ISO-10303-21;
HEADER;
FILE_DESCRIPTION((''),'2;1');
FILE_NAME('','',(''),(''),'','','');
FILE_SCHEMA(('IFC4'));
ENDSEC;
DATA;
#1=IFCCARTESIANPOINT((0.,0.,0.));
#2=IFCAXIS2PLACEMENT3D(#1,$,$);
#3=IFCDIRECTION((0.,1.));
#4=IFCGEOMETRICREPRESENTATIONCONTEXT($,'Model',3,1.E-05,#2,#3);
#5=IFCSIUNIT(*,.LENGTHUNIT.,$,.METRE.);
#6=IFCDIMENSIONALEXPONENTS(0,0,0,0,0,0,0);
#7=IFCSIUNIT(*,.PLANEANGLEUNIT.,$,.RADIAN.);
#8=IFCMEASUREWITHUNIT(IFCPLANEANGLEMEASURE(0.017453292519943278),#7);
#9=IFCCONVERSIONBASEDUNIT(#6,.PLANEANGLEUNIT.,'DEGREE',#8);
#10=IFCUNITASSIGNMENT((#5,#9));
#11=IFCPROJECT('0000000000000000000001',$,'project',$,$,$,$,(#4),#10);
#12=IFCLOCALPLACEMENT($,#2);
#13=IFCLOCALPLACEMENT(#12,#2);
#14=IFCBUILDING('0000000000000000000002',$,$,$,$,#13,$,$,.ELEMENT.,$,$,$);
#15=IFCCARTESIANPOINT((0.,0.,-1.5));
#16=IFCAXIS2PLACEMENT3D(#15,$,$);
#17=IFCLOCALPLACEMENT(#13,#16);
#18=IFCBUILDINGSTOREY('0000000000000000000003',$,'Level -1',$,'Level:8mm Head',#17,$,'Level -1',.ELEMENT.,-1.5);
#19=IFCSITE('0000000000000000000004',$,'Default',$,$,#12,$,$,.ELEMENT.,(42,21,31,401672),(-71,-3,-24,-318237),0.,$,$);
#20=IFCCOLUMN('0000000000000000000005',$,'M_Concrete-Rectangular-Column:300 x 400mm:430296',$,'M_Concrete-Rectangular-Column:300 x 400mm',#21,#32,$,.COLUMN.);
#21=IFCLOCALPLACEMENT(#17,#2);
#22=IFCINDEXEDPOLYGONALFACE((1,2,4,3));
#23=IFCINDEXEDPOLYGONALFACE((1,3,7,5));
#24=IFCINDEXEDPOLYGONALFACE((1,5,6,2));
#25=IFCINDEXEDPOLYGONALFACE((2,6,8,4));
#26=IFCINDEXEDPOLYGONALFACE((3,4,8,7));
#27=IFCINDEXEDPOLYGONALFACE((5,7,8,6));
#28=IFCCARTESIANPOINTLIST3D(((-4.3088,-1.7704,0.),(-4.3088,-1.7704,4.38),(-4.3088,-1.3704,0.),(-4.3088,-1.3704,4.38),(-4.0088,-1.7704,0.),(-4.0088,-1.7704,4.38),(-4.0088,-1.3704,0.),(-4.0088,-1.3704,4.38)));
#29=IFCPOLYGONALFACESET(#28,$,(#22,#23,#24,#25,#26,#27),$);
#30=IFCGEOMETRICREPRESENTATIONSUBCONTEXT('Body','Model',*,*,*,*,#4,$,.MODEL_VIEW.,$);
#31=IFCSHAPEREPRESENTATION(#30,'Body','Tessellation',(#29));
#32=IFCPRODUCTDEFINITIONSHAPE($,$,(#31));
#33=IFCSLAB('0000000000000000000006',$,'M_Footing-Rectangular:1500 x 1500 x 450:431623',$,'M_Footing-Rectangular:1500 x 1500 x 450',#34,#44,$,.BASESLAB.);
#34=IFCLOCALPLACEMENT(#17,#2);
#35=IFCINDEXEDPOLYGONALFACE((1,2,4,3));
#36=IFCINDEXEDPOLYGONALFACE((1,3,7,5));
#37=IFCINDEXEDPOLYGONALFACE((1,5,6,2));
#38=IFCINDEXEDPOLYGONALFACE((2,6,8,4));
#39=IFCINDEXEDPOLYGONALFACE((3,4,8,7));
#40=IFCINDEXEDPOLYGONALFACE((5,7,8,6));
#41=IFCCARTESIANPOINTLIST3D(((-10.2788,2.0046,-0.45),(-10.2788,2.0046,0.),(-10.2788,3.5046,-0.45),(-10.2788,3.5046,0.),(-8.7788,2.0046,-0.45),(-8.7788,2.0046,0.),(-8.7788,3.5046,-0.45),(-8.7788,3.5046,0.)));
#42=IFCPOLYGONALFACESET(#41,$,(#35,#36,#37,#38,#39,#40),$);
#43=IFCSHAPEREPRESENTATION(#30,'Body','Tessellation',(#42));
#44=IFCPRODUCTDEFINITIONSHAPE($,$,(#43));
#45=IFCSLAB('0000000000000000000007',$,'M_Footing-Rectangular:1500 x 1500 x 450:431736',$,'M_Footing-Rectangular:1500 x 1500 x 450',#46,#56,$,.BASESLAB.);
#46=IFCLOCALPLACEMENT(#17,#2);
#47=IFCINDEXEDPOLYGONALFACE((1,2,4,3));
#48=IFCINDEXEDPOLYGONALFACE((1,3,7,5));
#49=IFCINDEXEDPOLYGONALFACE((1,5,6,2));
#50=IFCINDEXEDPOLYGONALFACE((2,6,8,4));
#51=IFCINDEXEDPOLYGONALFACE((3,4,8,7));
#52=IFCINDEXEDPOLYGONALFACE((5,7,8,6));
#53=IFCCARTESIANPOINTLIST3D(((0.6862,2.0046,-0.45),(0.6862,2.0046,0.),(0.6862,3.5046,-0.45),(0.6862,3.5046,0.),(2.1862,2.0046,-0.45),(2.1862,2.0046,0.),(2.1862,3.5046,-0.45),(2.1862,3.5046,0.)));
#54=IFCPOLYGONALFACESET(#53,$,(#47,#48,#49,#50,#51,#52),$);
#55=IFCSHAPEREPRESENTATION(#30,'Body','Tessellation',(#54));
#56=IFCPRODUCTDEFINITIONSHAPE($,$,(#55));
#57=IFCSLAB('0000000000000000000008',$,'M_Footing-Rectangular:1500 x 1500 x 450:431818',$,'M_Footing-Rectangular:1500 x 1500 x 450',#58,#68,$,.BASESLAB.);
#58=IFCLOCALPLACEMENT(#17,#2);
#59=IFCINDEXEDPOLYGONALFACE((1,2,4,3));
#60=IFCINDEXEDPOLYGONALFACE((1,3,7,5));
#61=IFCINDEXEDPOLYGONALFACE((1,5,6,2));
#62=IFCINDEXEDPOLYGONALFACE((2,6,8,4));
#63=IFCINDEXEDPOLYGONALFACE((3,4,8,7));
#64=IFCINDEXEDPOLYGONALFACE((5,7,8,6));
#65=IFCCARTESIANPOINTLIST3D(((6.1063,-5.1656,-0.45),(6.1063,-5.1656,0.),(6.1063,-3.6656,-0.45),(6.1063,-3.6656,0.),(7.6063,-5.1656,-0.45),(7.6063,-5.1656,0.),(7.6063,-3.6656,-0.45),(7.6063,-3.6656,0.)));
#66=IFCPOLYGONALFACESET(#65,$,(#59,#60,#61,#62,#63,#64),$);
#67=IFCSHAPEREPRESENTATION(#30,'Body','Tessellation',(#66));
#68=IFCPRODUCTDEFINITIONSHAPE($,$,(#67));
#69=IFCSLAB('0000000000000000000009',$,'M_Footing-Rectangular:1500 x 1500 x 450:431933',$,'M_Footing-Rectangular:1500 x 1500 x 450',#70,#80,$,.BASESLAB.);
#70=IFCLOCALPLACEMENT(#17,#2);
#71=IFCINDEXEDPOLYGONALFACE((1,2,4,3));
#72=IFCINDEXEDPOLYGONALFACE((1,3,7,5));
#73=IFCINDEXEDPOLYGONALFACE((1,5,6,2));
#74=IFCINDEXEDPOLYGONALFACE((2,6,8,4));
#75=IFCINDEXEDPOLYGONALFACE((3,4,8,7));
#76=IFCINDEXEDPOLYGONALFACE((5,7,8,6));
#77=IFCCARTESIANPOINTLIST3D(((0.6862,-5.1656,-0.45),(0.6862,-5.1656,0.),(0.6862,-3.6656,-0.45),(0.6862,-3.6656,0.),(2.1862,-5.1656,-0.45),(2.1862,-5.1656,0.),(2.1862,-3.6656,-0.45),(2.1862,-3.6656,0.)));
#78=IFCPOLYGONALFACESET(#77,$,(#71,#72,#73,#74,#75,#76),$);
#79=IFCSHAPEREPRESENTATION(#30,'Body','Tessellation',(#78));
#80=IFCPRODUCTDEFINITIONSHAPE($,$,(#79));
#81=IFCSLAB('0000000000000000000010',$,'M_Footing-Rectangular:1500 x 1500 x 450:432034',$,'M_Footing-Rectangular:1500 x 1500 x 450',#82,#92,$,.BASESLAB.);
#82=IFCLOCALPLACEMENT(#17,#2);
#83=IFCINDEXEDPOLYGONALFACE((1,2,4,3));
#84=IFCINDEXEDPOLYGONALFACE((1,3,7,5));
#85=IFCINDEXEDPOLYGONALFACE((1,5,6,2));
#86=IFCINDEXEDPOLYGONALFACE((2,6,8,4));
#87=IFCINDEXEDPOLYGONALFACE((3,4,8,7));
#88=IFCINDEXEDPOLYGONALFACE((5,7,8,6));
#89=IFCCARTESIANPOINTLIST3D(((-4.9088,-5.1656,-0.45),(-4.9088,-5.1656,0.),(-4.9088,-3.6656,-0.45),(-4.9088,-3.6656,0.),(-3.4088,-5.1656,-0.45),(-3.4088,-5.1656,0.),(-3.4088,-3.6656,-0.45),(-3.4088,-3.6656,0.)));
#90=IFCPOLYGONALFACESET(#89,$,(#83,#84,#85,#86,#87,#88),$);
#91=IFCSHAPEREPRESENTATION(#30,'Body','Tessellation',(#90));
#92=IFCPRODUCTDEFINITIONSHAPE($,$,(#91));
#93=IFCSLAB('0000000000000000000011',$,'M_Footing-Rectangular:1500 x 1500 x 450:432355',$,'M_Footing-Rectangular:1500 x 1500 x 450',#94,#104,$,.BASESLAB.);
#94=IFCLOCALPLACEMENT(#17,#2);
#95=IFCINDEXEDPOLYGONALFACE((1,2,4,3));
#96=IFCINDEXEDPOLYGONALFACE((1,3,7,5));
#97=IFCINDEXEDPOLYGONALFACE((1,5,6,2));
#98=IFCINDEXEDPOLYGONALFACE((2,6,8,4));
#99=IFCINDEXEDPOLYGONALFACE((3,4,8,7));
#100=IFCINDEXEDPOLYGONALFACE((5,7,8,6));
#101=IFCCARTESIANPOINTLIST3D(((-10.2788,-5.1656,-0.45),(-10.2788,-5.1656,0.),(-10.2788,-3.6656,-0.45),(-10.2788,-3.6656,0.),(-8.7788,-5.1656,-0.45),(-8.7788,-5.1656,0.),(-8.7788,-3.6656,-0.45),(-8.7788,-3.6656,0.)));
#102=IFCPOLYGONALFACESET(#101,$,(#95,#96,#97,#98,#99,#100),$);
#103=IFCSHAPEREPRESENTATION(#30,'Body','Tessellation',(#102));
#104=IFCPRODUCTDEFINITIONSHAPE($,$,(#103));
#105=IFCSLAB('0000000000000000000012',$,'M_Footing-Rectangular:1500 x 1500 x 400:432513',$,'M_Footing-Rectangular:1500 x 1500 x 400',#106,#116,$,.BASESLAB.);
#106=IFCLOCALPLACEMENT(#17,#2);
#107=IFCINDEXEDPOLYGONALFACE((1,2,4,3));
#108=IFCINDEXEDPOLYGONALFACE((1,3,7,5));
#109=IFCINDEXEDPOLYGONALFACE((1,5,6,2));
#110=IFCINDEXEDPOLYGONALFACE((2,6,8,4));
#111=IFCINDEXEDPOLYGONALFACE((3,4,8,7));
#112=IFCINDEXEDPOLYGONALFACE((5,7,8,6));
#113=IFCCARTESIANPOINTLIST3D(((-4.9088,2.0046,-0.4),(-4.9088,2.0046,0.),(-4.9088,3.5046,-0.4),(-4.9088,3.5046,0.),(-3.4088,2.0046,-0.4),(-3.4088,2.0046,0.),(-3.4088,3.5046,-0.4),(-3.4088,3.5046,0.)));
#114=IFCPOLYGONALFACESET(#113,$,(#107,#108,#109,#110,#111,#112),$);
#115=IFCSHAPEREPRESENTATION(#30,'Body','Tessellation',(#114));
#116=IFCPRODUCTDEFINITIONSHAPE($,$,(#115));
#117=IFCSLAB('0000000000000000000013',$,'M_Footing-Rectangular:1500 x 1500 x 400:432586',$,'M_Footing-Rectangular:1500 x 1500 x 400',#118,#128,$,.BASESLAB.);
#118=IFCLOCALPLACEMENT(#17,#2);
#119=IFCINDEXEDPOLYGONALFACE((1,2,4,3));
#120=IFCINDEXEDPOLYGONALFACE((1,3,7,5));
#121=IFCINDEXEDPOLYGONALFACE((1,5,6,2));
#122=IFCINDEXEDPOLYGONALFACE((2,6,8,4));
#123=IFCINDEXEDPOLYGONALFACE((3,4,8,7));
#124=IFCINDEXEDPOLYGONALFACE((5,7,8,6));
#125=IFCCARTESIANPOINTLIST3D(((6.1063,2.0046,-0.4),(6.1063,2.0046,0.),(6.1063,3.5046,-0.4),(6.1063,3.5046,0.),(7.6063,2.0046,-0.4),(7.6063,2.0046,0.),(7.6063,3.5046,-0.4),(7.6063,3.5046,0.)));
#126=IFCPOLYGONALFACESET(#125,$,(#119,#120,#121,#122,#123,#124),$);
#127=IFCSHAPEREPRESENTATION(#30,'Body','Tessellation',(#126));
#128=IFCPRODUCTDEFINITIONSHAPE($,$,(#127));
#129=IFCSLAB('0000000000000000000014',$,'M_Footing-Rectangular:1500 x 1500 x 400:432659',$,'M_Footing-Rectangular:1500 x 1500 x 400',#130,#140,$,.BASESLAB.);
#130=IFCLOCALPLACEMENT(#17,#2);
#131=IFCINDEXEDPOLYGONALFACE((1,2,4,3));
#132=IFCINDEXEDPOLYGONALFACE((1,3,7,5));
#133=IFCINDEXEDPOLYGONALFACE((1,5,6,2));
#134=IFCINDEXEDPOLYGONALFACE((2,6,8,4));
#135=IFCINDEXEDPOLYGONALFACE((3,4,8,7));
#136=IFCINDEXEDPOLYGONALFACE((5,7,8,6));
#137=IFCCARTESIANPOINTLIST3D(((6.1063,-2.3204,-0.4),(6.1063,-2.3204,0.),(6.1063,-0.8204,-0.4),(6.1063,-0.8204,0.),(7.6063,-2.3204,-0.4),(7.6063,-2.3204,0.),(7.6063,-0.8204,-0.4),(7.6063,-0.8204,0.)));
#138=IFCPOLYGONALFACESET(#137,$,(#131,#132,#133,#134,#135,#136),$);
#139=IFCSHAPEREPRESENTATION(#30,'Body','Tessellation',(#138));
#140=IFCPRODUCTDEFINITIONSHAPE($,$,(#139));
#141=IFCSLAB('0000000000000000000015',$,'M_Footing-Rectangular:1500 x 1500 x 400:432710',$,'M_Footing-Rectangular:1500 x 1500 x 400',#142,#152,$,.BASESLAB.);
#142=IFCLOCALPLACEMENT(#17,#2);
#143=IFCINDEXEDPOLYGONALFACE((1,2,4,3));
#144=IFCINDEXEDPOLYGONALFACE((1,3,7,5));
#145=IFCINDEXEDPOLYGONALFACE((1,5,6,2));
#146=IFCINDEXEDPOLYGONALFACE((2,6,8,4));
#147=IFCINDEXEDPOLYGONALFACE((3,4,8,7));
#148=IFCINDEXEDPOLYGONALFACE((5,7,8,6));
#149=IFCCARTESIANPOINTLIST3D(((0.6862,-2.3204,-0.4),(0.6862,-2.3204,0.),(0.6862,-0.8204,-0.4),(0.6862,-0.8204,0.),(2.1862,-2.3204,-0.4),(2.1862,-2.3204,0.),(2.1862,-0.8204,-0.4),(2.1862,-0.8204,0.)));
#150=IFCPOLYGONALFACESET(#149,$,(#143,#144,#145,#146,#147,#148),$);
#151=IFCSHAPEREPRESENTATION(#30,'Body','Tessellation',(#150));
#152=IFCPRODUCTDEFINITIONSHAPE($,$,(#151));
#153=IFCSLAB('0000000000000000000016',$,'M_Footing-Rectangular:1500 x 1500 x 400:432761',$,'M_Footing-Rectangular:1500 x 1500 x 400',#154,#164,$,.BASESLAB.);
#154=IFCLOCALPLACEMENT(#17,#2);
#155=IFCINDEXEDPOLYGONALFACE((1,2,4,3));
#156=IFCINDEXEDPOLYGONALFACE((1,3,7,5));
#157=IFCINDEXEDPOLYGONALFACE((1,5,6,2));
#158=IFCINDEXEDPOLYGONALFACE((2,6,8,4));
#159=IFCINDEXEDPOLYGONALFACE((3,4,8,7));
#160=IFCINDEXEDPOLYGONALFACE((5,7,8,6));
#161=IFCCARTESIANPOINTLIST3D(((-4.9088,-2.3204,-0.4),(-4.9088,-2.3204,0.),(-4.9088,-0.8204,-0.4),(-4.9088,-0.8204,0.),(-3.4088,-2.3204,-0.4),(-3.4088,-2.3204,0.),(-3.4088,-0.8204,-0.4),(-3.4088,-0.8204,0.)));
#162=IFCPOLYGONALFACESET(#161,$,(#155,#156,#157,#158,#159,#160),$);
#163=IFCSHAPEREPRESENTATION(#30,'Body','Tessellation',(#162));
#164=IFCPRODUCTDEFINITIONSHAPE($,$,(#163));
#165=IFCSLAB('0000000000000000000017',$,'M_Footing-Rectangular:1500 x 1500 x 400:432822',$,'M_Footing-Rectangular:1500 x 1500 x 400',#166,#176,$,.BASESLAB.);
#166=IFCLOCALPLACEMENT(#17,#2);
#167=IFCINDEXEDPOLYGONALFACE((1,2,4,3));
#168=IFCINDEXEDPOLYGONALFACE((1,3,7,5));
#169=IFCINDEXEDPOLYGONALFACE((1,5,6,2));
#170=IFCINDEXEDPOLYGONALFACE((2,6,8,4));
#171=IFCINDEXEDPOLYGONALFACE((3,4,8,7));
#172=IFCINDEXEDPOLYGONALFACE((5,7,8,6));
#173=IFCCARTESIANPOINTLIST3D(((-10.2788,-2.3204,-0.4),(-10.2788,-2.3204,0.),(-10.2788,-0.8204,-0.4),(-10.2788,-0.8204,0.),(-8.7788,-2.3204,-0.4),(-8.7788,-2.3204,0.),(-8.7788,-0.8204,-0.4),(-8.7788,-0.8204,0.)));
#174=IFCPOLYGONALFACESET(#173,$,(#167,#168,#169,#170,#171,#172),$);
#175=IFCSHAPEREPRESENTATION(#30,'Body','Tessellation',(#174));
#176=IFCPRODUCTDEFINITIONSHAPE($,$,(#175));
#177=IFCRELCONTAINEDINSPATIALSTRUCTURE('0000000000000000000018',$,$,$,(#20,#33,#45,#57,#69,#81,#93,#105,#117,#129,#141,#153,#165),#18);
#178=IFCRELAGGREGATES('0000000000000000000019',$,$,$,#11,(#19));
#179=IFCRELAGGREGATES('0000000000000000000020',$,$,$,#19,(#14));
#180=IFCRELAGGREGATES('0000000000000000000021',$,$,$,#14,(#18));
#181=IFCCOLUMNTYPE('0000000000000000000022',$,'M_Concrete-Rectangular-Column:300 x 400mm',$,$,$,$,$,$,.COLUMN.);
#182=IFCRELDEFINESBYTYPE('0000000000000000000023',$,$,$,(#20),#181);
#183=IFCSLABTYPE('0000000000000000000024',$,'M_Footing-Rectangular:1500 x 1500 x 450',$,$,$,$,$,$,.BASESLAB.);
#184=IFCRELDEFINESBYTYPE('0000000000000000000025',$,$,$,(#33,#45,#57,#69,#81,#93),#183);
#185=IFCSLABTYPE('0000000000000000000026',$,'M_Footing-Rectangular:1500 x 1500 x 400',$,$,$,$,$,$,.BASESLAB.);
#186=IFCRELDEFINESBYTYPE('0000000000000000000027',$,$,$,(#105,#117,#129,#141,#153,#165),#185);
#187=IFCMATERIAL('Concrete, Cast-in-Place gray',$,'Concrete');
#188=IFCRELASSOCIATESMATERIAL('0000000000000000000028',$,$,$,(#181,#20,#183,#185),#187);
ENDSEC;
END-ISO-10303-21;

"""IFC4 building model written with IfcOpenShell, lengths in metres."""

from ifc_helpers import new_model, entity, si_unit, converted_unit, direction, frame, origin, place, context, subcontext, project, spatial, indexed_curve, outline, extrude, source, transform, mapped, material, type_object, type_shapes, element, save


model = new_model("IFC4")

# Units and contexts
model_context = context("Model", 3, precision=1e-05, world=origin(), true_north=direction((0.0, 1.0)))
body_context = subcontext(model_context, "Body", "Model", "MODEL_VIEW")
ifc_project = project(units=[si_unit("LENGTHUNIT", "METRE"), converted_unit("PLANEANGLEUNIT", "DEGREE", entity("IfcPlaneAngleMeasure", 0.017453292519943278), si_unit("PLANEANGLEUNIT", "RADIAN"), dimensions=[0, 0, 0, 0, 0, 0, 0])], contexts=[model_context])

# Site, building, storey
site_placement = place(None, origin())
site = spatial("IfcSite", under=ifc_project, at=site_placement, Name="Default", CompositionType="ELEMENT", RefLatitude=(42, 21, 31, 401672), RefLongitude=(-71, -3, -24, -318237), RefElevation=0.0)
building_placement = place(site_placement, origin())
building = spatial("IfcBuilding", under=site, at=building_placement, CompositionType="ELEMENT")
storey_placement = place(building_placement, frame((0.0, 0.0, -1.5)))
storey = spatial("IfcBuildingStorey", under=building, at=storey_placement, Name="Level -1", ObjectType="Level:8mm Head", LongName="Level -1", CompositionType="ELEMENT", Elevation=-1.5)

# Column
ifc_material = material(Name="Concrete, Cast-in-Place gray", Category="Concrete")
column_type_1 = type_object("IfcColumnType", Name="M_Concrete-Rectangular-Column:300 x 400mm", PredefinedType="COLUMN", material=ifc_material)
shared_shape_1 = source(origin(), body_context, "Body", "SweptSolid", [
    extrude(outline(indexed_curve([(-0.15, -0.2), (0.15, -0.2), (0.15, 0.2), (-0.15, 0.2), (-0.15, -0.2)], self_intersect=False)), frame((-4.1588, -1.5704, -1.5), z_axis=(0.0, 0.0, 1.0), x_axis=(-1.0, 0.0, 0.0)), (0.0, 0.0, 1.0), 4.38),
])
type_shapes(column_type_1, [shared_shape_1])
column_1_placement = place(storey_placement, frame((0.0, 0.0, 1.5)))
element("IfcColumn", 1, at=column_1_placement, inside=storey, type_object=column_type_1, material=ifc_material, Name="M_Concrete-Rectangular-Column:300 x 400mm:430296", ObjectType="M_Concrete-Rectangular-Column:300 x 400mm", PredefinedType="COLUMN", context=body_context, shape_type="MappedRepresentation", body=[
    mapped(shared_shape_1, transform((0.0, 0.0, 0.0), scale=1.0)),
])

# Slabs
slab_type_1 = type_object("IfcSlabType", Name="M_Footing-Rectangular:1500 x 1500 x 450", PredefinedType="BASESLAB", material=ifc_material)
slab_1_placement = place(storey_placement, origin())
element("IfcSlab", 2, at=slab_1_placement, inside=storey, type_object=slab_type_1, Name="M_Footing-Rectangular:1500 x 1500 x 450:431623", ObjectType="M_Footing-Rectangular:1500 x 1500 x 450", PredefinedType="BASESLAB", context=body_context, shape_type="SweptSolid", body=[
    extrude(outline(indexed_curve([(-0.75, -0.75), (0.75, -0.75), (0.75, 0.75), (-0.75, 0.75), (-0.75, -0.75)], self_intersect=False)), frame((-9.5288, 2.7546, -0.45), z_axis=(0.0, 0.0, 1.0), x_axis=(-1.0, 0.0, 0.0)), (0.0, 0.0, 1.0), 0.45),
])
slab_2_placement = place(storey_placement, origin())
element("IfcSlab", 3, at=slab_2_placement, inside=storey, type_object=slab_type_1, Name="M_Footing-Rectangular:1500 x 1500 x 450:431736", ObjectType="M_Footing-Rectangular:1500 x 1500 x 450", PredefinedType="BASESLAB", context=body_context, shape_type="SweptSolid", body=[
    extrude(outline(indexed_curve([(-0.75, -0.75), (0.75, -0.75), (0.75, 0.75), (-0.75, 0.75), (-0.75, -0.75)], self_intersect=False)), frame((1.4362, 2.7546, -0.45), z_axis=(0.0, 0.0, 1.0), x_axis=(-1.0, 0.0, 0.0)), (0.0, 0.0, 1.0), 0.45),
])
slab_3_placement = place(storey_placement, origin())
element("IfcSlab", 4, at=slab_3_placement, inside=storey, type_object=slab_type_1, Name="M_Footing-Rectangular:1500 x 1500 x 450:431818", ObjectType="M_Footing-Rectangular:1500 x 1500 x 450", PredefinedType="BASESLAB", context=body_context, shape_type="SweptSolid", body=[
    extrude(outline(indexed_curve([(-0.75, -0.75), (0.75, -0.75), (0.75, 0.75), (-0.75, 0.75), (-0.75, -0.75)], self_intersect=False)), frame((6.8563, -4.4156, -0.45), z_axis=(0.0, 0.0, 1.0), x_axis=(-1.0, 0.0, 0.0)), (0.0, 0.0, 1.0), 0.45),
])
slab_4_placement = place(storey_placement, origin())
element("IfcSlab", 5, at=slab_4_placement, inside=storey, type_object=slab_type_1, Name="M_Footing-Rectangular:1500 x 1500 x 450:431933", ObjectType="M_Footing-Rectangular:1500 x 1500 x 450", PredefinedType="BASESLAB", context=body_context, shape_type="SweptSolid", body=[
    extrude(outline(indexed_curve([(-0.75, -0.75), (0.75, -0.75), (0.75, 0.75), (-0.75, 0.75), (-0.75, -0.75)], self_intersect=False)), frame((1.4362, -4.4156, -0.45), z_axis=(0.0, 0.0, 1.0), x_axis=(-1.0, 0.0, 0.0)), (0.0, 0.0, 1.0), 0.45),
])
slab_5_placement = place(storey_placement, origin())
element("IfcSlab", 6, at=slab_5_placement, inside=storey, type_object=slab_type_1, Name="M_Footing-Rectangular:1500 x 1500 x 450:432034", ObjectType="M_Footing-Rectangular:1500 x 1500 x 450", PredefinedType="BASESLAB", context=body_context, shape_type="SweptSolid", body=[
    extrude(outline(indexed_curve([(-0.75, -0.75), (0.75, -0.75), (0.75, 0.75), (-0.75, 0.75), (-0.75, -0.75)], self_intersect=False)), frame((-4.1588, -4.4156, -0.45), z_axis=(0.0, 0.0, 1.0), x_axis=(-1.0, 0.0, 0.0)), (0.0, 0.0, 1.0), 0.45),
])
slab_6_placement = place(storey_placement, origin())
element("IfcSlab", 7, at=slab_6_placement, inside=storey, type_object=slab_type_1, Name="M_Footing-Rectangular:1500 x 1500 x 450:432355", ObjectType="M_Footing-Rectangular:1500 x 1500 x 450", PredefinedType="BASESLAB", context=body_context, shape_type="SweptSolid", body=[
    extrude(outline(indexed_curve([(-0.75, -0.75), (0.75, -0.75), (0.75, 0.75), (-0.75, 0.75), (-0.75, -0.75)], self_intersect=False)), frame((-9.5288, -4.4156, -0.45), z_axis=(0.0, 0.0, 1.0), x_axis=(-1.0, 0.0, 0.0)), (0.0, 0.0, 1.0), 0.45),
])
slab_type_2 = type_object("IfcSlabType", Name="M_Footing-Rectangular:1500 x 1500 x 400", PredefinedType="BASESLAB", material=ifc_material)
slab_7_placement = place(storey_placement, origin())
element("IfcSlab", 8, at=slab_7_placement, inside=storey, type_object=slab_type_2, Name="M_Footing-Rectangular:1500 x 1500 x 400:432513", ObjectType="M_Footing-Rectangular:1500 x 1500 x 400", PredefinedType="BASESLAB", context=body_context, shape_type="SweptSolid", body=[
    extrude(outline(indexed_curve([(-0.75, -0.75), (0.75, -0.75), (0.75, 0.75), (-0.75, 0.75), (-0.75, -0.75)], self_intersect=False)), frame((-4.1588, 2.7546, -0.4), z_axis=(0.0, 0.0, 1.0), x_axis=(-1.0, 0.0, 0.0)), (0.0, 0.0, 1.0), 0.4),
])
slab_8_placement = place(storey_placement, origin())
element("IfcSlab", 9, at=slab_8_placement, inside=storey, type_object=slab_type_2, Name="M_Footing-Rectangular:1500 x 1500 x 400:432586", ObjectType="M_Footing-Rectangular:1500 x 1500 x 400", PredefinedType="BASESLAB", context=body_context, shape_type="SweptSolid", body=[
    extrude(outline(indexed_curve([(-0.75, -0.75), (0.75, -0.75), (0.75, 0.75), (-0.75, 0.75), (-0.75, -0.75)], self_intersect=False)), frame((6.8563, 2.7546, -0.4), z_axis=(0.0, 0.0, 1.0), x_axis=(-1.0, 0.0, 0.0)), (0.0, 0.0, 1.0), 0.4),
])
slab_9_placement = place(storey_placement, origin())
element("IfcSlab", 10, at=slab_9_placement, inside=storey, type_object=slab_type_2, Name="M_Footing-Rectangular:1500 x 1500 x 400:432659", ObjectType="M_Footing-Rectangular:1500 x 1500 x 400", PredefinedType="BASESLAB", context=body_context, shape_type="SweptSolid", body=[
    extrude(outline(indexed_curve([(-0.75, -0.75), (0.75, -0.75), (0.75, 0.75), (-0.75, 0.75), (-0.75, -0.75)], self_intersect=False)), frame((6.8563, -1.5704, -0.4), z_axis=(0.0, 0.0, 1.0), x_axis=(-1.0, 0.0, 0.0)), (0.0, 0.0, 1.0), 0.4),
])
slab_10_placement = place(storey_placement, origin())
element("IfcSlab", 11, at=slab_10_placement, inside=storey, type_object=slab_type_2, Name="M_Footing-Rectangular:1500 x 1500 x 400:432710", ObjectType="M_Footing-Rectangular:1500 x 1500 x 400", PredefinedType="BASESLAB", context=body_context, shape_type="SweptSolid", body=[
    extrude(outline(indexed_curve([(-0.75, -0.75), (0.75, -0.75), (0.75, 0.75), (-0.75, 0.75), (-0.75, -0.75)], self_intersect=False)), frame((1.4362, -1.5704, -0.4), z_axis=(0.0, 0.0, 1.0), x_axis=(-1.0, 0.0, 0.0)), (0.0, 0.0, 1.0), 0.4),
])
slab_11_placement = place(storey_placement, origin())
element("IfcSlab", 12, at=slab_11_placement, inside=storey, type_object=slab_type_2, Name="M_Footing-Rectangular:1500 x 1500 x 400:432761", ObjectType="M_Footing-Rectangular:1500 x 1500 x 400", PredefinedType="BASESLAB", context=body_context, shape_type="SweptSolid", body=[
    extrude(outline(indexed_curve([(-0.75, -0.75), (0.75, -0.75), (0.75, 0.75), (-0.75, 0.75), (-0.75, -0.75)], self_intersect=False)), frame((-4.1588, -1.5704, -0.4), z_axis=(0.0, 0.0, 1.0), x_axis=(-1.0, 0.0, 0.0)), (0.0, 0.0, 1.0), 0.4),
])
slab_12_placement = place(storey_placement, origin())
element("IfcSlab", 13, at=slab_12_placement, inside=storey, type_object=slab_type_2, Name="M_Footing-Rectangular:1500 x 1500 x 400:432822", ObjectType="M_Footing-Rectangular:1500 x 1500 x 400", PredefinedType="BASESLAB", context=body_context, shape_type="SweptSolid", body=[
    extrude(outline(indexed_curve([(-0.75, -0.75), (0.75, -0.75), (0.75, 0.75), (-0.75, 0.75), (-0.75, -0.75)], self_intersect=False)), frame((-9.5288, -1.5704, -0.4), z_axis=(0.0, 0.0, 1.0), x_axis=(-1.0, 0.0, 0.0)), (0.0, 0.0, 1.0), 0.4),
])

save(model, "model.ifc")
